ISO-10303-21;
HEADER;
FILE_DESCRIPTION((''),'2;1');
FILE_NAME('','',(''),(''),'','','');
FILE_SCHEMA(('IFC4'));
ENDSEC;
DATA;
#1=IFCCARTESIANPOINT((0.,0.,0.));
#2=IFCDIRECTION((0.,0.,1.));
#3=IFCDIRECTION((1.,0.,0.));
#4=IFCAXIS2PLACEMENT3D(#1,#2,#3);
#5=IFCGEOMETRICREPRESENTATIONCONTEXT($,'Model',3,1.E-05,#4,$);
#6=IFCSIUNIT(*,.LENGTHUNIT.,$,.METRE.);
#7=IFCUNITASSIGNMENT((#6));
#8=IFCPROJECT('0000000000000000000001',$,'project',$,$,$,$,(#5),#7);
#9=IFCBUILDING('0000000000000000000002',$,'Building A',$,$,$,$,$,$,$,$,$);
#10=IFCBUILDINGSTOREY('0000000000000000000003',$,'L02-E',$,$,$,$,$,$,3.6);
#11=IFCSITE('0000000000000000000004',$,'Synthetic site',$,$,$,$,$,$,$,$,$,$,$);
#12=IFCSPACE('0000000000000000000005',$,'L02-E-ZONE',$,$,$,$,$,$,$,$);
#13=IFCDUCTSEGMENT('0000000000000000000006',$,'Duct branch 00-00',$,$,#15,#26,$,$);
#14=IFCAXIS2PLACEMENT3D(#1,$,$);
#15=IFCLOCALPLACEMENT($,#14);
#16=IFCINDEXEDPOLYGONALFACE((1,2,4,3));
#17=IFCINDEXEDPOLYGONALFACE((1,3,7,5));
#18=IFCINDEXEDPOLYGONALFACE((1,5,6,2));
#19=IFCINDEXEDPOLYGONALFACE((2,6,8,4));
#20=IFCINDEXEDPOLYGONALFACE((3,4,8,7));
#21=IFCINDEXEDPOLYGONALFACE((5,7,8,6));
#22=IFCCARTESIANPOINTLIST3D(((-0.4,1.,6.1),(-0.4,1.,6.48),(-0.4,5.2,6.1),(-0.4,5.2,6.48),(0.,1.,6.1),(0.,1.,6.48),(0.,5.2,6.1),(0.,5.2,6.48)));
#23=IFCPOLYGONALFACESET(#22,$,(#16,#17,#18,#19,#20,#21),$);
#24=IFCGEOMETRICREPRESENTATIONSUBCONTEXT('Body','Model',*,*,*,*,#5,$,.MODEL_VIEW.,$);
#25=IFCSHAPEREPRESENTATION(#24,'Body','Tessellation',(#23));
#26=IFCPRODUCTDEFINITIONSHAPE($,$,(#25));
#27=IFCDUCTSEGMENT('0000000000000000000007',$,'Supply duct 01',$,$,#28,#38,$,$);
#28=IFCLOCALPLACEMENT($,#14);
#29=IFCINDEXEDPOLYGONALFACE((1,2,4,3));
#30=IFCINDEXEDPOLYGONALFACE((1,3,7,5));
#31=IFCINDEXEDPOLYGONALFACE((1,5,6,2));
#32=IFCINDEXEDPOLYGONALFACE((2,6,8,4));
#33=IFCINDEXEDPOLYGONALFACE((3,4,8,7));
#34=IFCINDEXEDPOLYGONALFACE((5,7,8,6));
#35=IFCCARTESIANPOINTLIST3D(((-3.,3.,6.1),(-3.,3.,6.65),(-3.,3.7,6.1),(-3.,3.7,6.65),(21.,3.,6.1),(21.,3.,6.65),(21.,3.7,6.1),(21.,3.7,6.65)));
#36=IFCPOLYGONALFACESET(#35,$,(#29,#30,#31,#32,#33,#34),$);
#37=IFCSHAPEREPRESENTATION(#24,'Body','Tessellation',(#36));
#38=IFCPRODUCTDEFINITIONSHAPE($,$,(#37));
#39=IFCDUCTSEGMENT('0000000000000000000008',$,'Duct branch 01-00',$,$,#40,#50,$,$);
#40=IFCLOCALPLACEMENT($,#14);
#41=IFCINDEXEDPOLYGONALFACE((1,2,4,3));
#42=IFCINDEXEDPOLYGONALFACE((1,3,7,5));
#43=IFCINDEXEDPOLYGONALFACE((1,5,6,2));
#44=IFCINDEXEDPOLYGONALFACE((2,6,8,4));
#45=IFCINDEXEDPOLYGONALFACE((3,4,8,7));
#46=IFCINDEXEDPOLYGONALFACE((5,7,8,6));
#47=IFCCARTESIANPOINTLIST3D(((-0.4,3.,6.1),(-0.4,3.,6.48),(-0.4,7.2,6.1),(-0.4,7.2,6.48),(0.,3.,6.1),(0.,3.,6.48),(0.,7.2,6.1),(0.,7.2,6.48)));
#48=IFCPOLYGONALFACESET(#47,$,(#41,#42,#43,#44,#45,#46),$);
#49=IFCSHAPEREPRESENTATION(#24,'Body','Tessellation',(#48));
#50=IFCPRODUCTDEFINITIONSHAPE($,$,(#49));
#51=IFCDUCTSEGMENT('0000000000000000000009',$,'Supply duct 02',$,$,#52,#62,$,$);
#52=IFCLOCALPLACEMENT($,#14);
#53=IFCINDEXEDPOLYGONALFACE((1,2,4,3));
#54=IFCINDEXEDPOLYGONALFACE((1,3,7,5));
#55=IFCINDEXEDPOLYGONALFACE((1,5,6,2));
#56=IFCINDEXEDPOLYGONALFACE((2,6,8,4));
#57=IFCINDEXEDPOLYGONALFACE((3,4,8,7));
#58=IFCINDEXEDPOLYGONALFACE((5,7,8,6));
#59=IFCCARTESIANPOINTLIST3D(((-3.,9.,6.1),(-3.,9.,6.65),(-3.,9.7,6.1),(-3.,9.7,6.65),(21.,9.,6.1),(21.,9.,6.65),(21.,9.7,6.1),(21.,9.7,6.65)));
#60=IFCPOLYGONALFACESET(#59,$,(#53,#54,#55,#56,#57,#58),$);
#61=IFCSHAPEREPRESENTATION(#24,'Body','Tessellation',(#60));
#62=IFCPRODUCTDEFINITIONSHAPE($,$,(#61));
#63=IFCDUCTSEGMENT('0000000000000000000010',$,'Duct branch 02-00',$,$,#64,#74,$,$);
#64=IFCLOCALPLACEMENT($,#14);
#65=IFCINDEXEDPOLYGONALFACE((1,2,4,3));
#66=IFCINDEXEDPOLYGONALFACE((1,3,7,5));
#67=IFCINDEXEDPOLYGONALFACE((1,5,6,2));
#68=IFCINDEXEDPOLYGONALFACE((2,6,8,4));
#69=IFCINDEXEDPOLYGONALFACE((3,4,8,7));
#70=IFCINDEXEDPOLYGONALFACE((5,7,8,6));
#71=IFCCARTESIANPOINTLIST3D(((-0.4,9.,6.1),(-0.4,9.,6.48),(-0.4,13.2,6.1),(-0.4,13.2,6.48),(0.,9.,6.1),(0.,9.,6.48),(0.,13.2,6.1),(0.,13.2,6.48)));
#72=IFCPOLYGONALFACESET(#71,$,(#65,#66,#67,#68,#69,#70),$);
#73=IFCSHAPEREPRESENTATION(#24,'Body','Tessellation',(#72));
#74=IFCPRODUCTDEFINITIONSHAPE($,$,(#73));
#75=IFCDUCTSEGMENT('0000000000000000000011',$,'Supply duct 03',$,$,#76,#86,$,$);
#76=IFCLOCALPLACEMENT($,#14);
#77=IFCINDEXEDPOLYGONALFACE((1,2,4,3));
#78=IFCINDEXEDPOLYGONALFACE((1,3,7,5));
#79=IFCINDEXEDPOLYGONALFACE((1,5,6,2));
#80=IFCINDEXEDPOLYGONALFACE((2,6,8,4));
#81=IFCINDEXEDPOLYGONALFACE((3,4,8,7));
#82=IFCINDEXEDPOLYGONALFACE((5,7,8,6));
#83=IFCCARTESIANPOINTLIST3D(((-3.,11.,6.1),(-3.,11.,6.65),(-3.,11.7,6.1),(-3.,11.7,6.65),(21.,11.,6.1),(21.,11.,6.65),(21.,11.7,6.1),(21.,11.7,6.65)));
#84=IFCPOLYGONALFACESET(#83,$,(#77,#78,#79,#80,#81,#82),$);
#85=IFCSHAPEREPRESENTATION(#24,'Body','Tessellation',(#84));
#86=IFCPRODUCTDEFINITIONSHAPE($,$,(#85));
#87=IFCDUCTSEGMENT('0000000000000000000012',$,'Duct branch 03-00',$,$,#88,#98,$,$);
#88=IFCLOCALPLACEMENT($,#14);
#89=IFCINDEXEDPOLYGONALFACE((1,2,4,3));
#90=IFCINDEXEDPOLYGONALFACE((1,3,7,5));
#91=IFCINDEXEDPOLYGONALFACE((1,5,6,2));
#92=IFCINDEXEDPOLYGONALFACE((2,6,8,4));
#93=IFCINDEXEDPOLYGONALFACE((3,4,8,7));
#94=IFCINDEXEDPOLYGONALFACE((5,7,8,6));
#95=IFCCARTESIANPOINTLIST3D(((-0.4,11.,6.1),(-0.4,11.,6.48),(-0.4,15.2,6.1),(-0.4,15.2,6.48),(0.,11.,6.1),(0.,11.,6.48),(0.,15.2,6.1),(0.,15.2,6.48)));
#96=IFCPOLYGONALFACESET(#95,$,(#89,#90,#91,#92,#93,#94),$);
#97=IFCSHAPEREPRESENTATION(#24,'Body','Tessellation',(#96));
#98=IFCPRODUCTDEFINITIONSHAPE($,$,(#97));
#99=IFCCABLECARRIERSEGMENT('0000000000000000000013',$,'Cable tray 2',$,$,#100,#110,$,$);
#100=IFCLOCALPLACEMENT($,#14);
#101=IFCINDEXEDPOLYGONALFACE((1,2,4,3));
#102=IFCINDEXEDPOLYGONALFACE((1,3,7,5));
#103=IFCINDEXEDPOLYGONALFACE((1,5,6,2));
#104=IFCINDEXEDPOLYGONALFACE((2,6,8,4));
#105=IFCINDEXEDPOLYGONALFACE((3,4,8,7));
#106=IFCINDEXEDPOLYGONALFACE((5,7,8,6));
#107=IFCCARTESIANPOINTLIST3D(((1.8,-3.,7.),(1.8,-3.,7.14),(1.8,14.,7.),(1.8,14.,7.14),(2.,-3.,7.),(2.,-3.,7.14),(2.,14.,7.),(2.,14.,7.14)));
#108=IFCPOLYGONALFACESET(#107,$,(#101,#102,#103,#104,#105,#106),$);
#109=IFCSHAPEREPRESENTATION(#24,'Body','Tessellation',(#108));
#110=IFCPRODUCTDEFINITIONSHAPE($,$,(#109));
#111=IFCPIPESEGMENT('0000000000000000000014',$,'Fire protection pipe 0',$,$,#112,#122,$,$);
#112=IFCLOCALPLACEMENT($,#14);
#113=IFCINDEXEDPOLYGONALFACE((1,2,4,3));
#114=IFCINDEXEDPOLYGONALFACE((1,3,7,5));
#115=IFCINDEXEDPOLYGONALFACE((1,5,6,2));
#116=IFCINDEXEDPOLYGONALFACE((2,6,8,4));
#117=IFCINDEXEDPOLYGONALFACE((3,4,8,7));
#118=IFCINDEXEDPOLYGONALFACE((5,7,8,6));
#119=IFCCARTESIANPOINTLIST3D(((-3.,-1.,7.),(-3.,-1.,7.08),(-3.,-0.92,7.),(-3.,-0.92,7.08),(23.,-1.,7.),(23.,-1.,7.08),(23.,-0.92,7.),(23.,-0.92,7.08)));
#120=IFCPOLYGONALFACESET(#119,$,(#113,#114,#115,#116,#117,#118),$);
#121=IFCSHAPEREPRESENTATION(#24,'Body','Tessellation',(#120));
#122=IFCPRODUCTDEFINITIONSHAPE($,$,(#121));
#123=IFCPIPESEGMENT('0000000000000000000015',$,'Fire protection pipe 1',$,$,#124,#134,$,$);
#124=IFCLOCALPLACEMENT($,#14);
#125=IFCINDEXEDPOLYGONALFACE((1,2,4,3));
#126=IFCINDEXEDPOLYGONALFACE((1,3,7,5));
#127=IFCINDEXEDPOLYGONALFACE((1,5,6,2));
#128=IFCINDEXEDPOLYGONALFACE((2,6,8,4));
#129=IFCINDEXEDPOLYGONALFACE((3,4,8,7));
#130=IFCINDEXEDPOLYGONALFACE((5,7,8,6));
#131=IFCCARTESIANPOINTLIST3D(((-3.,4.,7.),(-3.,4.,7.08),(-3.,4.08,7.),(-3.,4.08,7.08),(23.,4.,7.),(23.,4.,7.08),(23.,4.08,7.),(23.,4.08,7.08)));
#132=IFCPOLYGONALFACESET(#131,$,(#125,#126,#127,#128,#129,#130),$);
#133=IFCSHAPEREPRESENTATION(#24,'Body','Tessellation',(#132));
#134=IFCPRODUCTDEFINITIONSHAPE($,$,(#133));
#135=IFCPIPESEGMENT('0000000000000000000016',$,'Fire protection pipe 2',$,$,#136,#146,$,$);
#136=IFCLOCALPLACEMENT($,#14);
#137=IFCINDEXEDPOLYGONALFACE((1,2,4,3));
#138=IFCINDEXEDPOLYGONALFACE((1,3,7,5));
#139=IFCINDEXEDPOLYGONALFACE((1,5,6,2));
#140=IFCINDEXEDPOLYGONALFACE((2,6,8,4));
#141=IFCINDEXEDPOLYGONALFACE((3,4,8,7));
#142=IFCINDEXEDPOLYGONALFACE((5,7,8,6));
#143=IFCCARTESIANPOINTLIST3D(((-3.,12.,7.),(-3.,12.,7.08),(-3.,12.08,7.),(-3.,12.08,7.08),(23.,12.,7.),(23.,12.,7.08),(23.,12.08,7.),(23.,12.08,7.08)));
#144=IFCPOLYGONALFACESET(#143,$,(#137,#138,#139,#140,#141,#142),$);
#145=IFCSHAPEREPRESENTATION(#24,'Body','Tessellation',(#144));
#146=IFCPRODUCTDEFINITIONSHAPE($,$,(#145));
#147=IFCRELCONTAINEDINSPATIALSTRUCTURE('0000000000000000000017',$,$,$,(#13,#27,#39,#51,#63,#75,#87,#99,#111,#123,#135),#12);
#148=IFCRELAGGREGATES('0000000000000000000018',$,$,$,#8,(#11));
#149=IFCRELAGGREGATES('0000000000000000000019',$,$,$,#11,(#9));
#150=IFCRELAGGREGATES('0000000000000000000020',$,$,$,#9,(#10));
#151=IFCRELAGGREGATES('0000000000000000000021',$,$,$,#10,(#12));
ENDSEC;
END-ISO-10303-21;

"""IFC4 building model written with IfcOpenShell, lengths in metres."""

from ifc_helpers import new_model, si_unit, frame, origin_with_axes, place, context, subcontext, project, spatial, indexed_curve, outline, extrude, element, save


model = new_model("IFC4")

# Units and contexts
model_context = context("Model", 3, precision=1e-05, world=origin_with_axes())
body_context = subcontext(model_context, "Body", "Model", "MODEL_VIEW")
ifc_project = project(units=[si_unit("LENGTHUNIT", "METRE")], contexts=[model_context])

# Site, building, storey, space
site = spatial("IfcSite", under=ifc_project, Name="Synthetic site")
building = spatial("IfcBuilding", under=site, Name="Building A")
storey = spatial("IfcBuildingStorey", under=building, Name="L02-E", Elevation=3.6)
space = spatial("IfcSpace", under=storey, Name="L02-E-ZONE")

# Duct segments
duct_segment_1_placement = place(None, frame((0.0, 1.0, 6.1), z_axis=(0.0, 0.0, 1.0), x_axis=(0.0, 1.0, 0.0)))
element("IfcDuctSegment", 1, at=duct_segment_1_placement, inside=space, Name="Duct branch 00-00", context=body_context, shape_type="SweptSolid", body=[
    extrude(outline(indexed_curve([(0.0, 0.0), (0.0, 0.4), (4.2, 0.4), (4.2, 0.0), (0.0, 0.0)], self_intersect=False)), origin_with_axes(), (0.0, 0.0, 1.0), 0.38),
])
duct_segment_2_placement = place(None, frame((-3.0, 3.0, 6.1), z_axis=(0.0, 0.0, 1.0), x_axis=(1.0, 0.0, 0.0)))
element("IfcDuctSegment", 2, at=duct_segment_2_placement, inside=space, Name="Supply duct 01", context=body_context, shape_type="SweptSolid", body=[
    extrude(outline(indexed_curve([(0.0, 0.0), (0.0, 0.7), (24.0, 0.7), (24.0, 0.0), (0.0, 0.0)], self_intersect=False)), origin_with_axes(), (0.0, 0.0, 1.0), 0.55),
])
duct_segment_3_placement = place(None, frame((0.0, 3.0, 6.1), z_axis=(0.0, 0.0, 1.0), x_axis=(0.0, 1.0, 0.0)))
element("IfcDuctSegment", 3, at=duct_segment_3_placement, inside=space, Name="Duct branch 01-00", context=body_context, shape_type="SweptSolid", body=[
    extrude(outline(indexed_curve([(0.0, 0.0), (0.0, 0.4), (4.2, 0.4), (4.2, 0.0), (0.0, 0.0)], self_intersect=False)), origin_with_axes(), (0.0, 0.0, 1.0), 0.38),
])
duct_segment_4_placement = place(None, frame((-3.0, 9.0, 6.1), z_axis=(0.0, 0.0, 1.0), x_axis=(1.0, 0.0, 0.0)))
element("IfcDuctSegment", 4, at=duct_segment_4_placement, inside=space, Name="Supply duct 02", context=body_context, shape_type="SweptSolid", body=[
    extrude(outline(indexed_curve([(0.0, 0.0), (0.0, 0.7), (24.0, 0.7), (24.0, 0.0), (0.0, 0.0)], self_intersect=False)), origin_with_axes(), (0.0, 0.0, 1.0), 0.55),
])
duct_segment_5_placement = place(None, frame((0.0, 9.0, 6.1), z_axis=(0.0, 0.0, 1.0), x_axis=(0.0, 1.0, 0.0)))
element("IfcDuctSegment", 5, at=duct_segment_5_placement, inside=space, Name="Duct branch 02-00", context=body_context, shape_type="SweptSolid", body=[
    extrude(outline(indexed_curve([(0.0, 0.0), (0.0, 0.4), (4.2, 0.4), (4.2, 0.0), (0.0, 0.0)], self_intersect=False)), origin_with_axes(), (0.0, 0.0, 1.0), 0.38),
])
duct_segment_6_placement = place(None, frame((-3.0, 11.0, 6.1), z_axis=(0.0, 0.0, 1.0), x_axis=(1.0, 0.0, 0.0)))
element("IfcDuctSegment", 6, at=duct_segment_6_placement, inside=space, Name="Supply duct 03", context=body_context, shape_type="SweptSolid", body=[
    extrude(outline(indexed_curve([(0.0, 0.0), (0.0, 0.7), (24.0, 0.7), (24.0, 0.0), (0.0, 0.0)], self_intersect=False)), origin_with_axes(), (0.0, 0.0, 1.0), 0.55),
])
duct_segment_7_placement = place(None, frame((0.0, 11.0, 6.1), z_axis=(0.0, 0.0, 1.0), x_axis=(0.0, 1.0, 0.0)))
element("IfcDuctSegment", 7, at=duct_segment_7_placement, inside=space, Name="Duct branch 03-00", context=body_context, shape_type="SweptSolid", body=[
    extrude(outline(indexed_curve([(0.0, 0.0), (0.0, 0.4), (4.2, 0.4), (4.2, 0.0), (0.0, 0.0)], self_intersect=False)), origin_with_axes(), (0.0, 0.0, 1.0), 0.38),
])

# Cable carrier segment
cable_carrier_segment_placement = place(None, frame((2.0, -3.0, 7.0), z_axis=(0.0, 0.0, 1.0), x_axis=(0.0, 1.0, 0.0)))
element("IfcCableCarrierSegment", 8, at=cable_carrier_segment_placement, inside=space, Name="Cable tray 2", context=body_context, shape_type="SweptSolid", body=[
    extrude(outline(indexed_curve([(0.0, 0.0), (0.0, 0.2), (17.0, 0.2), (17.0, 0.0), (0.0, 0.0)], self_intersect=False)), origin_with_axes(), (0.0, 0.0, 1.0), 0.14),
])

# Pipe segments
for number, where, z_axis, x_axis, name in (
    (9, (-3.0, -1.0, 7.0), (0.0, 0.0, 1.0), (1.0, 0.0, 0.0), "Fire protection pipe 0"),
    (10, (-3.0, 4.0, 7.0), (0.0, 0.0, 1.0), (1.0, 0.0, 0.0), "Fire protection pipe 1"),
    (11, (-3.0, 12.0, 7.0), (0.0, 0.0, 1.0), (1.0, 0.0, 0.0), "Fire protection pipe 2"),
):
    element("IfcPipeSegment", number, at=place(None, frame(where, z_axis=z_axis, x_axis=x_axis)), inside=space, Name=name, context=body_context, shape_type="SweptSolid", body=[
        extrude(outline(indexed_curve([(0.0, 0.0), (0.0, 0.08), (26.0, 0.08), (26.0, 0.0), (0.0, 0.0)], self_intersect=False)), origin_with_axes(), (0.0, 0.0, 1.0), 0.08),
    ])

save(model, "model.ifc")
